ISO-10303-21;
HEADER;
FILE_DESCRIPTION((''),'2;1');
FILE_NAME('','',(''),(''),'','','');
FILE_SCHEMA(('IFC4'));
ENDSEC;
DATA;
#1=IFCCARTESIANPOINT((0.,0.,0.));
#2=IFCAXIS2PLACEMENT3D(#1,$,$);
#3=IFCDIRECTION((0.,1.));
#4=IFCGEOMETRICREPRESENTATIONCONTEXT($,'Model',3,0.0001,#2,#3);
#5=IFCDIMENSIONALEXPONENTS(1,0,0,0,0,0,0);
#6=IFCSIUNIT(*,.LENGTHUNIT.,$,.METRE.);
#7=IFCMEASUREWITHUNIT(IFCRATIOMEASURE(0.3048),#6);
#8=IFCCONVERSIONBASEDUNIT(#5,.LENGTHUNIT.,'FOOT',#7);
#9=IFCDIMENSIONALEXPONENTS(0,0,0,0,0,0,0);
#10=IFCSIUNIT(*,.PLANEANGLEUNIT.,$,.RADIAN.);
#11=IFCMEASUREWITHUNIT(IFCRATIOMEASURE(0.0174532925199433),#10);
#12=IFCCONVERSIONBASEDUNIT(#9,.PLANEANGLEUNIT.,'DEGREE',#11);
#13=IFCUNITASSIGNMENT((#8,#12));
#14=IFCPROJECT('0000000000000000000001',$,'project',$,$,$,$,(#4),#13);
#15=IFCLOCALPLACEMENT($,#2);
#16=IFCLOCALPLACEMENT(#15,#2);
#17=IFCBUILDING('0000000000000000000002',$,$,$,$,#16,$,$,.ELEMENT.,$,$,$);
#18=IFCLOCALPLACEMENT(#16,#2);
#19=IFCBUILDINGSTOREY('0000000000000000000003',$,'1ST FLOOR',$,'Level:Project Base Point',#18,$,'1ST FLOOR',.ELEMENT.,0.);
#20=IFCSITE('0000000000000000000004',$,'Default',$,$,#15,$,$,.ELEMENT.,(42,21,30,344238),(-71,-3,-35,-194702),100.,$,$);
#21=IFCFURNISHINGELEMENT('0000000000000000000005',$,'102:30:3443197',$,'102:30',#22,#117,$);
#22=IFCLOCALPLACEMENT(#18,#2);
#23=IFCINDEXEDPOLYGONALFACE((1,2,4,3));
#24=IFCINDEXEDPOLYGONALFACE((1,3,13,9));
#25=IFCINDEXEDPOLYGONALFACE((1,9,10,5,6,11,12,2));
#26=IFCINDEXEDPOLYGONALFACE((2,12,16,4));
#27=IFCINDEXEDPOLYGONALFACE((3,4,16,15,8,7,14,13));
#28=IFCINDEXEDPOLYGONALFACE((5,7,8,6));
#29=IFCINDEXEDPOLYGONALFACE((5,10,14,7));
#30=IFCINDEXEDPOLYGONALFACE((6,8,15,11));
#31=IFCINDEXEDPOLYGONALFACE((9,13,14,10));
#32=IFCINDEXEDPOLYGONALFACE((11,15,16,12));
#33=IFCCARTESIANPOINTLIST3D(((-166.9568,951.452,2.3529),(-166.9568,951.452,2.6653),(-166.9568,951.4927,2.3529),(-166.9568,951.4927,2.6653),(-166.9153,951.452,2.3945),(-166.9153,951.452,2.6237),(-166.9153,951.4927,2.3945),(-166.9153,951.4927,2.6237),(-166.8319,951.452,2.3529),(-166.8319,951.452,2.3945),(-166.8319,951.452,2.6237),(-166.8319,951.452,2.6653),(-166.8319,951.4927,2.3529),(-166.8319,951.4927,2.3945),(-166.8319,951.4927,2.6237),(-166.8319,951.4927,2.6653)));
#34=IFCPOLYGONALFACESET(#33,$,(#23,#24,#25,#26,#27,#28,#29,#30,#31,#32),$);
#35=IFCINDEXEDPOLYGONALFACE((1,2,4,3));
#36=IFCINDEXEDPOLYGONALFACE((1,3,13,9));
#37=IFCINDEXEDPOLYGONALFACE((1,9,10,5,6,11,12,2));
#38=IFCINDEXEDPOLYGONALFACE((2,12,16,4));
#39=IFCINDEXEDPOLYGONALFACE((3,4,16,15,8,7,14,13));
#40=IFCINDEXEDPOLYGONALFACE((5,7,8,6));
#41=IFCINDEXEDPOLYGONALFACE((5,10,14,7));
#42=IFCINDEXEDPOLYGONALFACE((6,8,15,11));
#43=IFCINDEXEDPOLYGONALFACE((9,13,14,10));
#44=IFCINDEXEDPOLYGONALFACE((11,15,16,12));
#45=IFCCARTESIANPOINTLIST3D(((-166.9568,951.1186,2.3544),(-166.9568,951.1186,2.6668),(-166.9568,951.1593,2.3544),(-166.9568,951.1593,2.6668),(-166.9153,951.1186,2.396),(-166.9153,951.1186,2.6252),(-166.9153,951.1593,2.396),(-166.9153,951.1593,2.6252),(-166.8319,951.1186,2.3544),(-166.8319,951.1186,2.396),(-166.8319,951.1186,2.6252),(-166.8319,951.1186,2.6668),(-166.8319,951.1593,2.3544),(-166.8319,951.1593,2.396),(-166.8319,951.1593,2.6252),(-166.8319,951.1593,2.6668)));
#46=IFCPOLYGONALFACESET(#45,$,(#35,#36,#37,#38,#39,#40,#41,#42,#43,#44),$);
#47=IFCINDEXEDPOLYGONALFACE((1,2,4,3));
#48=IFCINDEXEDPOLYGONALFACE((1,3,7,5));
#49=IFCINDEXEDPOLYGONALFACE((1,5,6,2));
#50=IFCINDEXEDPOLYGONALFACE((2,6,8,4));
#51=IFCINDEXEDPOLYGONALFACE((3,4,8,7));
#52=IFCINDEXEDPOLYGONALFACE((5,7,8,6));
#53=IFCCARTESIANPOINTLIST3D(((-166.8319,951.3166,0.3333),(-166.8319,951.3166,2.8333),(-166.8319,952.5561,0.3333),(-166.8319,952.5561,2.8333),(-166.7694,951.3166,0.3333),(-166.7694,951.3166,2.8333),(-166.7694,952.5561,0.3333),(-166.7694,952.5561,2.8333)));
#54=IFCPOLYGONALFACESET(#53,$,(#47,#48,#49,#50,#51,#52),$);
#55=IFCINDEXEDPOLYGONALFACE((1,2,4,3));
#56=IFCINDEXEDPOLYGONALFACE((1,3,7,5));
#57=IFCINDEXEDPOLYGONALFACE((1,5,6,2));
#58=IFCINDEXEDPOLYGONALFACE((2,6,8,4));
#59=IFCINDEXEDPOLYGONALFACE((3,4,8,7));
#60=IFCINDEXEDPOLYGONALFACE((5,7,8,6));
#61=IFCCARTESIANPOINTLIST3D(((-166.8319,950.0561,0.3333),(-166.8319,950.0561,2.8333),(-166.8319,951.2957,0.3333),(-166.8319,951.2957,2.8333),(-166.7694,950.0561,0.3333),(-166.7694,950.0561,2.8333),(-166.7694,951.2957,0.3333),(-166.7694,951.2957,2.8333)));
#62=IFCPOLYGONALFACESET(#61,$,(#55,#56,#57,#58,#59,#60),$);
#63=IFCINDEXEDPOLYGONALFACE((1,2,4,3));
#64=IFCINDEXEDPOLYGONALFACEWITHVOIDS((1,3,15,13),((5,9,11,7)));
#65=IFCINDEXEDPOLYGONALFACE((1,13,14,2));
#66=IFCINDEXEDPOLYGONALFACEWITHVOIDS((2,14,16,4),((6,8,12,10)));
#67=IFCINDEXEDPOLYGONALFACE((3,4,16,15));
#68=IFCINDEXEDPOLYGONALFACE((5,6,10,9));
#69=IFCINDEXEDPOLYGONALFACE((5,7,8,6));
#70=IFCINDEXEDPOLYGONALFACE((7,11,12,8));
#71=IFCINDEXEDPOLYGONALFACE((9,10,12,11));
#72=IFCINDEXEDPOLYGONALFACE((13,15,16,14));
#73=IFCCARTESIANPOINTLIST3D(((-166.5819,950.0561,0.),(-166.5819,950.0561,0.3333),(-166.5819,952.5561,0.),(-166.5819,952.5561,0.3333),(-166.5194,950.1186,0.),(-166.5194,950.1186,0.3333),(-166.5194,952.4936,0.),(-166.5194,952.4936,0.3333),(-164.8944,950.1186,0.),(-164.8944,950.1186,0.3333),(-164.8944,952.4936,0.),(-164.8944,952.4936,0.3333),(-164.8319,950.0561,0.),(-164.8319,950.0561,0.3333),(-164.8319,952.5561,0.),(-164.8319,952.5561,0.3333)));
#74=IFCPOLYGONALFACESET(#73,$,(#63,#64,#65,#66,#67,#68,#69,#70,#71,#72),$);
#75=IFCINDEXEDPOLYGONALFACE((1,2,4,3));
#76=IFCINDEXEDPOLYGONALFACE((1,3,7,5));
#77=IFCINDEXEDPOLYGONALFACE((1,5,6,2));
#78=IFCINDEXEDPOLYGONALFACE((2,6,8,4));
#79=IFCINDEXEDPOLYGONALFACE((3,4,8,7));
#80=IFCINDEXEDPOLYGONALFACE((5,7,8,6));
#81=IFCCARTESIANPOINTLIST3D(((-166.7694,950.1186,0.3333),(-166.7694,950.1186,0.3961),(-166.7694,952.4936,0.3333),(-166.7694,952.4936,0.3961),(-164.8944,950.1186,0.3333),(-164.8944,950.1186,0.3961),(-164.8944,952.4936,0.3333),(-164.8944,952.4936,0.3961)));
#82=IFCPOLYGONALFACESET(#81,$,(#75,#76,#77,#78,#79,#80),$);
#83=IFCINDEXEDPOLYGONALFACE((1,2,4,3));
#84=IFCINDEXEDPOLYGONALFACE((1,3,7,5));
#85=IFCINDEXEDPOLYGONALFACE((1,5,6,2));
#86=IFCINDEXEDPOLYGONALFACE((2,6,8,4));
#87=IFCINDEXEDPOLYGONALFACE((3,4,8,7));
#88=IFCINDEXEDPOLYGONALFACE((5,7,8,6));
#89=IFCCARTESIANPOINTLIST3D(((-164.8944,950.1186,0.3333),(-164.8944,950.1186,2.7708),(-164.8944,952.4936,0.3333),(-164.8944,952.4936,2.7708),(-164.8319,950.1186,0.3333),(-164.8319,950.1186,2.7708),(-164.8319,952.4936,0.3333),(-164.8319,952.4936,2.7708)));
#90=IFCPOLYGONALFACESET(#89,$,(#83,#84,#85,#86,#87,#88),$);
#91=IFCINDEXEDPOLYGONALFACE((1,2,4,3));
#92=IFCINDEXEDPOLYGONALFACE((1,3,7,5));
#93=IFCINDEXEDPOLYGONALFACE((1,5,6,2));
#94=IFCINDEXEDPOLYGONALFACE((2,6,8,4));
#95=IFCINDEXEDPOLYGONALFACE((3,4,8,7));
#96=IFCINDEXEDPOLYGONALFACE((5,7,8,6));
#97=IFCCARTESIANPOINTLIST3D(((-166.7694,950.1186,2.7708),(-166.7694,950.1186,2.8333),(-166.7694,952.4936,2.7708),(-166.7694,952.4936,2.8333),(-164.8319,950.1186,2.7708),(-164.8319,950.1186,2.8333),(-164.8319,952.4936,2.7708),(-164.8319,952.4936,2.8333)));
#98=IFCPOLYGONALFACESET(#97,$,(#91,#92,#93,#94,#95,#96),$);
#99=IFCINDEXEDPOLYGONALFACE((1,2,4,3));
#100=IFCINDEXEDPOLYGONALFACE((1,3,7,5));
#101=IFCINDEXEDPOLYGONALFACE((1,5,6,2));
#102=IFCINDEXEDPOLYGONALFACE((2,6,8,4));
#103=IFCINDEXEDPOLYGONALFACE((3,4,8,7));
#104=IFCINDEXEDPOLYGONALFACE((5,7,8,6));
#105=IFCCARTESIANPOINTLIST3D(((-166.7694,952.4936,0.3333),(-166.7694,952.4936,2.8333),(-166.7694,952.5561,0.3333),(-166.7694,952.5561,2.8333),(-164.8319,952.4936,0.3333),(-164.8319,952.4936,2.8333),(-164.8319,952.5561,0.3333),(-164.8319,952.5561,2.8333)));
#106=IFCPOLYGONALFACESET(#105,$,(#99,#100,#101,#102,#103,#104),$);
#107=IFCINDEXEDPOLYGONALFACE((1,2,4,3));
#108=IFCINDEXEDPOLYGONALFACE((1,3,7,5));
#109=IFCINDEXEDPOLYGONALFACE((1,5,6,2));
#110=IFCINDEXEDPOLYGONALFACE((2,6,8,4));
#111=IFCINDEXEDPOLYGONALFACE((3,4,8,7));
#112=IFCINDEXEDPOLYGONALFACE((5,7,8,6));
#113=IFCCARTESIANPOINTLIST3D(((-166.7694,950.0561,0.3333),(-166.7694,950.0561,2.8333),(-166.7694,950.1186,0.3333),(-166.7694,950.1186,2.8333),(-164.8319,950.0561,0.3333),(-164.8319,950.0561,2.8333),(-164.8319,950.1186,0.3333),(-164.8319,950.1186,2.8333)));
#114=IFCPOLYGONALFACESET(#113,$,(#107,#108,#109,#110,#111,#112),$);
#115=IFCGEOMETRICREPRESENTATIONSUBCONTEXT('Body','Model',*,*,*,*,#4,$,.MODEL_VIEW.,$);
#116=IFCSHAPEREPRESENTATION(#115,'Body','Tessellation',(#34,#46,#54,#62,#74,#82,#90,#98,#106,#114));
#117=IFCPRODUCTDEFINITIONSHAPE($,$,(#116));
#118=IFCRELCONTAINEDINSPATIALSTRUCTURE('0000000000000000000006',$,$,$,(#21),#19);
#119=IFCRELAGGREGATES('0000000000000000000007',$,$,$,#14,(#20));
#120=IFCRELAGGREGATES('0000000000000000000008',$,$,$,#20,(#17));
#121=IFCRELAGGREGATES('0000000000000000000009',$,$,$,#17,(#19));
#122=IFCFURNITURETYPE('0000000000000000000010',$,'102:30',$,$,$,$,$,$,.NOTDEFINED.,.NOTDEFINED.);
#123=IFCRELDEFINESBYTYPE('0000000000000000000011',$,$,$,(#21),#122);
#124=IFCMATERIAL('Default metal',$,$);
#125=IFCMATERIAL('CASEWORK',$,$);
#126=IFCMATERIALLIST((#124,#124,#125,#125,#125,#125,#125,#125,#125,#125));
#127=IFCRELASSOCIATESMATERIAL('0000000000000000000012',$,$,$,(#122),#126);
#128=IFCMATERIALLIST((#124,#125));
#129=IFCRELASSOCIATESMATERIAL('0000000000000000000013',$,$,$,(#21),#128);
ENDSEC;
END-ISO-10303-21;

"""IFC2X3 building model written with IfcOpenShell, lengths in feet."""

from ifc_helpers import new_model, entity, si_unit, converted_unit, direction, frame, frame_2d, origin, origin_2d_with_axis, place, context, subcontext, project, spatial, polyline, rectangle, outline, extrude, source, transform, mapped, material, material_list, type_object, type_shapes, element, save


model = new_model("IFC2X3")

# Units and contexts
model_context = context("Model", 3, precision=0.0001, world=origin(), true_north=direction((0.0, 1.0)))
body_context = subcontext(model_context, "Body", "Model", "MODEL_VIEW")
ifc_project = project(units=[converted_unit("LENGTHUNIT", "FOOT", entity("IfcRatioMeasure", 0.3048), si_unit("LENGTHUNIT", "METRE"), dimensions=[1, 0, 0, 0, 0, 0, 0]), converted_unit("PLANEANGLEUNIT", "DEGREE", entity("IfcRatioMeasure", 0.0174532925199433), si_unit("PLANEANGLEUNIT", "RADIAN"), dimensions=[0, 0, 0, 0, 0, 0, 0])], contexts=[model_context])

# Site, building, storey
site_placement = place(None, origin())
site = spatial("IfcSite", under=ifc_project, at=site_placement, Name="Default", CompositionType="ELEMENT", RefLatitude=(42, 21, 30, 344238), RefLongitude=(-71, -3, -35, -194702), RefElevation=100.0)
building_placement = place(site_placement, origin())
building = spatial("IfcBuilding", under=site, at=building_placement, CompositionType="ELEMENT")
storey_placement = place(building_placement, origin())
storey = spatial("IfcBuildingStorey", under=building, at=storey_placement, Name="1ST FLOOR", ObjectType="Level:Project Base Point", LongName="1ST FLOOR", CompositionType="ELEMENT", Elevation=0.0)

# Shared definitions
ifc_material_1 = material(Name="CASEWORK")

# Furnishing element
ifc_material_2 = material(Name="Default metal")
ifc_material_list_1 = material_list([ifc_material_2, ifc_material_1])
ifc_material_list_2 = material_list([ifc_material_2, ifc_material_2, ifc_material_1, ifc_material_1, ifc_material_1, ifc_material_1, ifc_material_1, ifc_material_1, ifc_material_1, ifc_material_1])
furniture_type_1 = type_object("IfcFurnitureType", Name="102:30", material=ifc_material_list_2)
shared_shape_1 = source(origin(), body_context, "Body", "SweptSolid", [
    extrude(outline(polyline([(-0.0521, -0.1146), (-0.0521, -0.1562), (0.0729, -0.1562), (0.0729, 0.1562), (-0.0521, 0.1562), (-0.0521, 0.1146), (0.0313, 0.1146), (0.0313, -0.1146), (-0.0521, -0.1146)])), frame((0.2073, 2.0521, 2.5091), z_axis=(-1.0, 0.0, 0.0), x_axis=(0.0, 1.0, 0.0)), (0.0, 0.0, -1.0), 0.0407),
    extrude(outline(polyline([(-0.0521, -0.1146), (-0.0521, -0.1562), (0.0729, -0.1562), (0.0729, 0.1562), (-0.0521, 0.1562), (-0.0521, 0.1146), (0.0313, 0.1146), (0.0313, -0.1146), (-0.0521, -0.1146)])), frame((-0.126, 2.0521, 2.5106), z_axis=(-1.0, 0.0, 0.0), x_axis=(0.0, 1.0, 0.0)), (0.0, 0.0, -1.0), 0.0407),
    extrude(rectangle(XDim=1.2396, YDim=0.0625, at=frame_2d((0.0, 0.0), x_axis=(1.0, 0.0))), frame((0.6917, 1.9688, 0.3333), z_axis=(0.0, 0.0, 1.0), x_axis=(-1.0, 0.0, 0.0)), (0.0, 0.0, 1.0), 2.5),
    extrude(rectangle(XDim=1.2396, YDim=0.0625, at=origin_2d_with_axis()), frame((-0.5687, 1.9688, 0.3333), z_axis=(0.0, 0.0, 1.0), x_axis=(-1.0, 0.0, 0.0)), (0.0, 0.0, 1.0), 2.5),
    extrude(outline(polyline([(-0.875, -1.25), (0.875, -1.25), (0.875, 1.25), (-0.875, 1.25), (-0.875, -1.25)]), holes=[polyline([(-0.8125, -1.1875), (-0.8125, 1.1875), (0.8125, 1.1875), (0.8125, -1.1875), (-0.8125, -1.1875)])]), frame((0.0615, 0.875, 0.0), z_axis=(0.0, 0.0, 1.0), x_axis=(0.0, -1.0, 0.0)), (0.0, 0.0, 1.0), 0.3333),
    extrude(rectangle(XDim=1.875, YDim=2.375, at=origin_2d_with_axis()), frame((0.0615, 1.0, 0.3333), z_axis=(0.0, 0.0, 1.0), x_axis=(0.0, 1.0, 0.0)), (0.0, 0.0, 1.0), 0.0627),
    extrude(rectangle(XDim=2.375, YDim=0.0625, at=origin_2d_with_axis()), frame((0.0615, 0.0312, 0.3333), z_axis=(0.0, 0.0, 1.0), x_axis=(-1.0, 0.0, 0.0)), (0.0, 0.0, 1.0), 2.4375),
    extrude(rectangle(XDim=1.9375, YDim=2.375, at=frame_2d((0.0, 0.0), x_axis=(1.0, 0.0))), frame((0.0615, 0.9688, 2.7708), z_axis=(0.0, 0.0, 1.0), x_axis=(0.0, 1.0, 0.0)), (0.0, 0.0, 1.0), 0.0625),
    extrude(rectangle(XDim=1.9375, YDim=0.0625, at=frame_2d((0.0, 0.0), x_axis=(1.0, 0.0))), frame((1.2802, 0.9687, 0.3333), z_axis=(0.0, 0.0, 1.0), x_axis=(0.0, -1.0, 0.0)), (0.0, 0.0, 1.0), 2.5),
    extrude(rectangle(XDim=1.9375, YDim=0.0625, at=frame_2d((0.0, 0.0), x_axis=(1.0, 0.0))), frame((-1.1573, 0.9687, 0.3333), z_axis=(0.0, 0.0, 1.0), x_axis=(0.0, -1.0, 0.0)), (0.0, 0.0, 1.0), 2.5),
])
type_shapes(furniture_type_1, [shared_shape_1])
furnishing_1_placement = place(storey_placement, frame((-164.8319, 951.2447, 0.0), z_axis=(0.0, 0.0, 1.0), x_axis=(0.0, 1.0, 0.0)))
element("IfcFurnishingElement", 1, at=furnishing_1_placement, inside=storey, type_object=furniture_type_1, material=ifc_material_list_1, Name="102:30:3443197", ObjectType="102:30", context=body_context, shape_type="MappedRepresentation", body=[
    mapped(shared_shape_1, transform((0.0, 0.0, 0.0), scale=1.0)),
])

save(model, "model.ifc")
